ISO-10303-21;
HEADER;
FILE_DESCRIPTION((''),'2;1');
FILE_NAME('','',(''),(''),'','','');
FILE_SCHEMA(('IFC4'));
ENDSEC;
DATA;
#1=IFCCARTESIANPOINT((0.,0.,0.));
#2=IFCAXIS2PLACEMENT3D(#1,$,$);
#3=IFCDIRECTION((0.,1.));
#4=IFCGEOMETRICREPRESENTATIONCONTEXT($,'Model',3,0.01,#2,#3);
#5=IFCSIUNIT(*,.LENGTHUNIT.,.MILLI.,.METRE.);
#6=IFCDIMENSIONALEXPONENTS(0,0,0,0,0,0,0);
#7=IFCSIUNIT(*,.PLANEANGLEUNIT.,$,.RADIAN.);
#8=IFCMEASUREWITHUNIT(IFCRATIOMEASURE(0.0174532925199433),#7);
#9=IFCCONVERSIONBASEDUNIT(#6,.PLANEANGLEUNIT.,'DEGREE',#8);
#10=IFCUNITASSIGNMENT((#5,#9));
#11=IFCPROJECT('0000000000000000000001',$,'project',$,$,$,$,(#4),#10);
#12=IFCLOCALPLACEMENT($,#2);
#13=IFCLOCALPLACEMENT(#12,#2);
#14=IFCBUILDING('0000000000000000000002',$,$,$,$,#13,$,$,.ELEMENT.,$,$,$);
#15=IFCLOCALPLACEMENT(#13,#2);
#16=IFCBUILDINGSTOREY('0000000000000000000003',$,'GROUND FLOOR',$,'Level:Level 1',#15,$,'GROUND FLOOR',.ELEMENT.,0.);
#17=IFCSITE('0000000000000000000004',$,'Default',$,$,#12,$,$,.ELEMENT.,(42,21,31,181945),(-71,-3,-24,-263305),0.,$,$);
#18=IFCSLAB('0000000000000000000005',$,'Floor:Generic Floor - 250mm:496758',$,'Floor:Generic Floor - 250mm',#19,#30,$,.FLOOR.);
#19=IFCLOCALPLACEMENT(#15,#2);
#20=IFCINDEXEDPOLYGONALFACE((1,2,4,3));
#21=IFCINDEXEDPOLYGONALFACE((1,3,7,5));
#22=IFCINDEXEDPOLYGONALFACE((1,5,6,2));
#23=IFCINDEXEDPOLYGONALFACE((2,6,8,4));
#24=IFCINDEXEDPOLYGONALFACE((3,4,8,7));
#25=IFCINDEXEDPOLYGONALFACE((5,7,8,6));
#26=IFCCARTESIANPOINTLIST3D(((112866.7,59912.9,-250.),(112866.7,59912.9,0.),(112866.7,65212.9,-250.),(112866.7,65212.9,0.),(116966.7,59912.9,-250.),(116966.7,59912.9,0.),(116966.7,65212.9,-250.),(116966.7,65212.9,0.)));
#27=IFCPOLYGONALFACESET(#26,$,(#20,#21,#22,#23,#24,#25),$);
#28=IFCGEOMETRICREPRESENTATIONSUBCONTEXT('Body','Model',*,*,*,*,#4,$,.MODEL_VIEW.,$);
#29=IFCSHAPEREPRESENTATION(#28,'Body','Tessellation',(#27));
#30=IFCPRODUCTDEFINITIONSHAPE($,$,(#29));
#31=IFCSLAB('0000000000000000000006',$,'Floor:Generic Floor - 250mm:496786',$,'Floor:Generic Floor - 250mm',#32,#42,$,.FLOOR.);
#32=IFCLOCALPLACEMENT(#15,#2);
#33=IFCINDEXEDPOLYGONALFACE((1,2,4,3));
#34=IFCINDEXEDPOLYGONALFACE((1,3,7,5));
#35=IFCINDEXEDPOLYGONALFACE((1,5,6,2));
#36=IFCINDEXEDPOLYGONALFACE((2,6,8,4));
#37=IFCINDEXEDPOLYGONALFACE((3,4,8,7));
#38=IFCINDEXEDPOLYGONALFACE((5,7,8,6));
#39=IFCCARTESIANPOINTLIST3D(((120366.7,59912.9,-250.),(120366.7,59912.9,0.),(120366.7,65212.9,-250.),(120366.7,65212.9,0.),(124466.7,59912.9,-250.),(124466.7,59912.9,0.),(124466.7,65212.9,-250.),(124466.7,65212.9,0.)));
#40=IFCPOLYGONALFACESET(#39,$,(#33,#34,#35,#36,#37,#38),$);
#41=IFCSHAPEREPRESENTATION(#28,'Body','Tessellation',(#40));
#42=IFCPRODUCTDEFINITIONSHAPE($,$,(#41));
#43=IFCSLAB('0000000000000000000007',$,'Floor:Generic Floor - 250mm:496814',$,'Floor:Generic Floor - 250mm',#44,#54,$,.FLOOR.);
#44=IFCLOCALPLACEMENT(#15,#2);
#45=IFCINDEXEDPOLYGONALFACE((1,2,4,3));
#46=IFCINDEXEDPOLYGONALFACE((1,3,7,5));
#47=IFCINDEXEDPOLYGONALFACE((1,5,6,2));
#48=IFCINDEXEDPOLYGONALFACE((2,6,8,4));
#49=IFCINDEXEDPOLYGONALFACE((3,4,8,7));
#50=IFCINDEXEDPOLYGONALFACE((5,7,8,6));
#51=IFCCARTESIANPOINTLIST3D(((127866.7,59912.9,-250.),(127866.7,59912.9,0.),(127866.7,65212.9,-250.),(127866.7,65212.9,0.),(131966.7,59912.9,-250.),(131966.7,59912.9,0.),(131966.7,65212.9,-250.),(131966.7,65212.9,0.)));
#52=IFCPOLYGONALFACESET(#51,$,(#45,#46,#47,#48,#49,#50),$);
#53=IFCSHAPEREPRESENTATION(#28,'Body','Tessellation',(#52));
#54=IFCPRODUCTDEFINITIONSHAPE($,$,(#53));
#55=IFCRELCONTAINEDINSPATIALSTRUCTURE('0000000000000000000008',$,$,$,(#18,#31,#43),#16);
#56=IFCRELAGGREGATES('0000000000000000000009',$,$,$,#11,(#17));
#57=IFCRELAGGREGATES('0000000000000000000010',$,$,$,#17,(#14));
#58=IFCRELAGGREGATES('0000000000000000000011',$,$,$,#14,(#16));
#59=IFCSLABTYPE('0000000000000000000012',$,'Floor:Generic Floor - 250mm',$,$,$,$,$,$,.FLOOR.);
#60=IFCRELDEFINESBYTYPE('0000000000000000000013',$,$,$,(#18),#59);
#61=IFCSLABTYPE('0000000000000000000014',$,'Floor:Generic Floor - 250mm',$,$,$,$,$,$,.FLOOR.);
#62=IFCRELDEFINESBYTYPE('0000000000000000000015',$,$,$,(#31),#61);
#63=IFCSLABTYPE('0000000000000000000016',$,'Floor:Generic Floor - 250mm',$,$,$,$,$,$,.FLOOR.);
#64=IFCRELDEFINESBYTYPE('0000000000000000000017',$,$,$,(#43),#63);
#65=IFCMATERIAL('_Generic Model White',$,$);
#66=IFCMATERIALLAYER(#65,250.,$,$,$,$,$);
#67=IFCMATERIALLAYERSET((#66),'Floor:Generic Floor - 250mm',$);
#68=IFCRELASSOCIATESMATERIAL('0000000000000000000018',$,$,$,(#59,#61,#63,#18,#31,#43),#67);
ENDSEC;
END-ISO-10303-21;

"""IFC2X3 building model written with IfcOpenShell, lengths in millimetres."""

from ifc_helpers import new_model, entity, si_unit, converted_unit, direction, frame, frame_2d, origin, place, context, subcontext, project, spatial, rectangle, extrude, material, layer, layer_set, layer_usage, type_object, element, save


model = new_model("IFC2X3")

# Units and contexts
model_context = context("Model", 3, precision=0.01, world=origin(), true_north=direction((0.0, 1.0)))
body_context = subcontext(model_context, "Body", "Model", "MODEL_VIEW")
ifc_project = project(units=[si_unit("LENGTHUNIT", "METRE", prefix="MILLI"), converted_unit("PLANEANGLEUNIT", "DEGREE", entity("IfcRatioMeasure", 0.0174532925199433), si_unit("PLANEANGLEUNIT", "RADIAN"), dimensions=[0, 0, 0, 0, 0, 0, 0])], contexts=[model_context])

# Site, building, storey
site_placement = place(None, origin())
site = spatial("IfcSite", under=ifc_project, at=site_placement, Name="Default", CompositionType="ELEMENT", RefLatitude=(42, 21, 31, 181945), RefLongitude=(-71, -3, -24, -263305), RefElevation=0.0)
building_placement = place(site_placement, origin())
building = spatial("IfcBuilding", under=site, at=building_placement, CompositionType="ELEMENT")
storey_placement = place(building_placement, origin())
storey = spatial("IfcBuildingStorey", under=building, at=storey_placement, Name="GROUND FLOOR", ObjectType="Level:Level 1", LongName="GROUND FLOOR", CompositionType="ELEMENT", Elevation=0.0)

# Slabs
ifc_material_1 = material(Name="_Generic Model White")
ifc_layer_1 = layer(ifc_material_1, 250.0)
ifc_layer_set_1 = layer_set([ifc_layer_1], Name="Floor:Generic Floor - 250mm")
ifc_layer_usage_1 = layer_usage(ifc_layer_set_1, "AXIS3", "POSITIVE", 0.0)
slab_type_1 = type_object("IfcSlabType", Name="Floor:Generic Floor - 250mm", PredefinedType="FLOOR", material=ifc_layer_set_1)
slab_1_placement = place(storey_placement, origin())
element("IfcSlab", 1, at=slab_1_placement, inside=storey, type_object=slab_type_1, material=ifc_layer_usage_1, Name="Floor:Generic Floor - 250mm:496758", ObjectType="Floor:Generic Floor - 250mm", PredefinedType="FLOOR", context=body_context, shape_type="SweptSolid", body=[
    extrude(rectangle(XDim=5300.0, YDim=4100.0, at=frame_2d((0.0, 0.0), x_axis=(1.0, 0.0))), frame((114916.7, 62562.9, 0.0), z_axis=(0.0, 0.0, -1.0), x_axis=(0.0, 1.0, 0.0)), (0.0, 0.0, 1.0), 250.0),
])
ifc_layer_usage_2 = layer_usage(ifc_layer_set_1, "AXIS3", "POSITIVE", 0.0)
slab_type_2 = type_object("IfcSlabType", Name="Floor:Generic Floor - 250mm", PredefinedType="FLOOR", material=ifc_layer_set_1)
slab_2_placement = place(storey_placement, origin())
element("IfcSlab", 2, at=slab_2_placement, inside=storey, type_object=slab_type_2, material=ifc_layer_usage_2, Name="Floor:Generic Floor - 250mm:496786", ObjectType="Floor:Generic Floor - 250mm", PredefinedType="FLOOR", context=body_context, shape_type="SweptSolid", body=[
    extrude(rectangle(XDim=5300.0, YDim=4100.0, at=frame_2d((0.0, 0.0), x_axis=(1.0, 0.0))), frame((122416.7, 62562.9, 0.0), z_axis=(0.0, 0.0, -1.0), x_axis=(0.0, 1.0, 0.0)), (0.0, 0.0, 1.0), 250.0),
])
ifc_layer_usage_3 = layer_usage(ifc_layer_set_1, "AXIS3", "POSITIVE", 0.0)
slab_type_3 = type_object("IfcSlabType", Name="Floor:Generic Floor - 250mm", PredefinedType="FLOOR", material=ifc_layer_set_1)
slab_3_placement = place(storey_placement, origin())
element("IfcSlab", 3, at=slab_3_placement, inside=storey, type_object=slab_type_3, material=ifc_layer_usage_3, Name="Floor:Generic Floor - 250mm:496814", ObjectType="Floor:Generic Floor - 250mm", PredefinedType="FLOOR", context=body_context, shape_type="SweptSolid", body=[
    extrude(rectangle(XDim=5300.0, YDim=4100.0, at=frame_2d((0.0, 0.0), x_axis=(1.0, 0.0))), frame((129916.7, 62562.9, 0.0), z_axis=(0.0, 0.0, -1.0), x_axis=(0.0, 1.0, 0.0)), (0.0, 0.0, 1.0), 250.0),
])

save(model, "model.ifc")
